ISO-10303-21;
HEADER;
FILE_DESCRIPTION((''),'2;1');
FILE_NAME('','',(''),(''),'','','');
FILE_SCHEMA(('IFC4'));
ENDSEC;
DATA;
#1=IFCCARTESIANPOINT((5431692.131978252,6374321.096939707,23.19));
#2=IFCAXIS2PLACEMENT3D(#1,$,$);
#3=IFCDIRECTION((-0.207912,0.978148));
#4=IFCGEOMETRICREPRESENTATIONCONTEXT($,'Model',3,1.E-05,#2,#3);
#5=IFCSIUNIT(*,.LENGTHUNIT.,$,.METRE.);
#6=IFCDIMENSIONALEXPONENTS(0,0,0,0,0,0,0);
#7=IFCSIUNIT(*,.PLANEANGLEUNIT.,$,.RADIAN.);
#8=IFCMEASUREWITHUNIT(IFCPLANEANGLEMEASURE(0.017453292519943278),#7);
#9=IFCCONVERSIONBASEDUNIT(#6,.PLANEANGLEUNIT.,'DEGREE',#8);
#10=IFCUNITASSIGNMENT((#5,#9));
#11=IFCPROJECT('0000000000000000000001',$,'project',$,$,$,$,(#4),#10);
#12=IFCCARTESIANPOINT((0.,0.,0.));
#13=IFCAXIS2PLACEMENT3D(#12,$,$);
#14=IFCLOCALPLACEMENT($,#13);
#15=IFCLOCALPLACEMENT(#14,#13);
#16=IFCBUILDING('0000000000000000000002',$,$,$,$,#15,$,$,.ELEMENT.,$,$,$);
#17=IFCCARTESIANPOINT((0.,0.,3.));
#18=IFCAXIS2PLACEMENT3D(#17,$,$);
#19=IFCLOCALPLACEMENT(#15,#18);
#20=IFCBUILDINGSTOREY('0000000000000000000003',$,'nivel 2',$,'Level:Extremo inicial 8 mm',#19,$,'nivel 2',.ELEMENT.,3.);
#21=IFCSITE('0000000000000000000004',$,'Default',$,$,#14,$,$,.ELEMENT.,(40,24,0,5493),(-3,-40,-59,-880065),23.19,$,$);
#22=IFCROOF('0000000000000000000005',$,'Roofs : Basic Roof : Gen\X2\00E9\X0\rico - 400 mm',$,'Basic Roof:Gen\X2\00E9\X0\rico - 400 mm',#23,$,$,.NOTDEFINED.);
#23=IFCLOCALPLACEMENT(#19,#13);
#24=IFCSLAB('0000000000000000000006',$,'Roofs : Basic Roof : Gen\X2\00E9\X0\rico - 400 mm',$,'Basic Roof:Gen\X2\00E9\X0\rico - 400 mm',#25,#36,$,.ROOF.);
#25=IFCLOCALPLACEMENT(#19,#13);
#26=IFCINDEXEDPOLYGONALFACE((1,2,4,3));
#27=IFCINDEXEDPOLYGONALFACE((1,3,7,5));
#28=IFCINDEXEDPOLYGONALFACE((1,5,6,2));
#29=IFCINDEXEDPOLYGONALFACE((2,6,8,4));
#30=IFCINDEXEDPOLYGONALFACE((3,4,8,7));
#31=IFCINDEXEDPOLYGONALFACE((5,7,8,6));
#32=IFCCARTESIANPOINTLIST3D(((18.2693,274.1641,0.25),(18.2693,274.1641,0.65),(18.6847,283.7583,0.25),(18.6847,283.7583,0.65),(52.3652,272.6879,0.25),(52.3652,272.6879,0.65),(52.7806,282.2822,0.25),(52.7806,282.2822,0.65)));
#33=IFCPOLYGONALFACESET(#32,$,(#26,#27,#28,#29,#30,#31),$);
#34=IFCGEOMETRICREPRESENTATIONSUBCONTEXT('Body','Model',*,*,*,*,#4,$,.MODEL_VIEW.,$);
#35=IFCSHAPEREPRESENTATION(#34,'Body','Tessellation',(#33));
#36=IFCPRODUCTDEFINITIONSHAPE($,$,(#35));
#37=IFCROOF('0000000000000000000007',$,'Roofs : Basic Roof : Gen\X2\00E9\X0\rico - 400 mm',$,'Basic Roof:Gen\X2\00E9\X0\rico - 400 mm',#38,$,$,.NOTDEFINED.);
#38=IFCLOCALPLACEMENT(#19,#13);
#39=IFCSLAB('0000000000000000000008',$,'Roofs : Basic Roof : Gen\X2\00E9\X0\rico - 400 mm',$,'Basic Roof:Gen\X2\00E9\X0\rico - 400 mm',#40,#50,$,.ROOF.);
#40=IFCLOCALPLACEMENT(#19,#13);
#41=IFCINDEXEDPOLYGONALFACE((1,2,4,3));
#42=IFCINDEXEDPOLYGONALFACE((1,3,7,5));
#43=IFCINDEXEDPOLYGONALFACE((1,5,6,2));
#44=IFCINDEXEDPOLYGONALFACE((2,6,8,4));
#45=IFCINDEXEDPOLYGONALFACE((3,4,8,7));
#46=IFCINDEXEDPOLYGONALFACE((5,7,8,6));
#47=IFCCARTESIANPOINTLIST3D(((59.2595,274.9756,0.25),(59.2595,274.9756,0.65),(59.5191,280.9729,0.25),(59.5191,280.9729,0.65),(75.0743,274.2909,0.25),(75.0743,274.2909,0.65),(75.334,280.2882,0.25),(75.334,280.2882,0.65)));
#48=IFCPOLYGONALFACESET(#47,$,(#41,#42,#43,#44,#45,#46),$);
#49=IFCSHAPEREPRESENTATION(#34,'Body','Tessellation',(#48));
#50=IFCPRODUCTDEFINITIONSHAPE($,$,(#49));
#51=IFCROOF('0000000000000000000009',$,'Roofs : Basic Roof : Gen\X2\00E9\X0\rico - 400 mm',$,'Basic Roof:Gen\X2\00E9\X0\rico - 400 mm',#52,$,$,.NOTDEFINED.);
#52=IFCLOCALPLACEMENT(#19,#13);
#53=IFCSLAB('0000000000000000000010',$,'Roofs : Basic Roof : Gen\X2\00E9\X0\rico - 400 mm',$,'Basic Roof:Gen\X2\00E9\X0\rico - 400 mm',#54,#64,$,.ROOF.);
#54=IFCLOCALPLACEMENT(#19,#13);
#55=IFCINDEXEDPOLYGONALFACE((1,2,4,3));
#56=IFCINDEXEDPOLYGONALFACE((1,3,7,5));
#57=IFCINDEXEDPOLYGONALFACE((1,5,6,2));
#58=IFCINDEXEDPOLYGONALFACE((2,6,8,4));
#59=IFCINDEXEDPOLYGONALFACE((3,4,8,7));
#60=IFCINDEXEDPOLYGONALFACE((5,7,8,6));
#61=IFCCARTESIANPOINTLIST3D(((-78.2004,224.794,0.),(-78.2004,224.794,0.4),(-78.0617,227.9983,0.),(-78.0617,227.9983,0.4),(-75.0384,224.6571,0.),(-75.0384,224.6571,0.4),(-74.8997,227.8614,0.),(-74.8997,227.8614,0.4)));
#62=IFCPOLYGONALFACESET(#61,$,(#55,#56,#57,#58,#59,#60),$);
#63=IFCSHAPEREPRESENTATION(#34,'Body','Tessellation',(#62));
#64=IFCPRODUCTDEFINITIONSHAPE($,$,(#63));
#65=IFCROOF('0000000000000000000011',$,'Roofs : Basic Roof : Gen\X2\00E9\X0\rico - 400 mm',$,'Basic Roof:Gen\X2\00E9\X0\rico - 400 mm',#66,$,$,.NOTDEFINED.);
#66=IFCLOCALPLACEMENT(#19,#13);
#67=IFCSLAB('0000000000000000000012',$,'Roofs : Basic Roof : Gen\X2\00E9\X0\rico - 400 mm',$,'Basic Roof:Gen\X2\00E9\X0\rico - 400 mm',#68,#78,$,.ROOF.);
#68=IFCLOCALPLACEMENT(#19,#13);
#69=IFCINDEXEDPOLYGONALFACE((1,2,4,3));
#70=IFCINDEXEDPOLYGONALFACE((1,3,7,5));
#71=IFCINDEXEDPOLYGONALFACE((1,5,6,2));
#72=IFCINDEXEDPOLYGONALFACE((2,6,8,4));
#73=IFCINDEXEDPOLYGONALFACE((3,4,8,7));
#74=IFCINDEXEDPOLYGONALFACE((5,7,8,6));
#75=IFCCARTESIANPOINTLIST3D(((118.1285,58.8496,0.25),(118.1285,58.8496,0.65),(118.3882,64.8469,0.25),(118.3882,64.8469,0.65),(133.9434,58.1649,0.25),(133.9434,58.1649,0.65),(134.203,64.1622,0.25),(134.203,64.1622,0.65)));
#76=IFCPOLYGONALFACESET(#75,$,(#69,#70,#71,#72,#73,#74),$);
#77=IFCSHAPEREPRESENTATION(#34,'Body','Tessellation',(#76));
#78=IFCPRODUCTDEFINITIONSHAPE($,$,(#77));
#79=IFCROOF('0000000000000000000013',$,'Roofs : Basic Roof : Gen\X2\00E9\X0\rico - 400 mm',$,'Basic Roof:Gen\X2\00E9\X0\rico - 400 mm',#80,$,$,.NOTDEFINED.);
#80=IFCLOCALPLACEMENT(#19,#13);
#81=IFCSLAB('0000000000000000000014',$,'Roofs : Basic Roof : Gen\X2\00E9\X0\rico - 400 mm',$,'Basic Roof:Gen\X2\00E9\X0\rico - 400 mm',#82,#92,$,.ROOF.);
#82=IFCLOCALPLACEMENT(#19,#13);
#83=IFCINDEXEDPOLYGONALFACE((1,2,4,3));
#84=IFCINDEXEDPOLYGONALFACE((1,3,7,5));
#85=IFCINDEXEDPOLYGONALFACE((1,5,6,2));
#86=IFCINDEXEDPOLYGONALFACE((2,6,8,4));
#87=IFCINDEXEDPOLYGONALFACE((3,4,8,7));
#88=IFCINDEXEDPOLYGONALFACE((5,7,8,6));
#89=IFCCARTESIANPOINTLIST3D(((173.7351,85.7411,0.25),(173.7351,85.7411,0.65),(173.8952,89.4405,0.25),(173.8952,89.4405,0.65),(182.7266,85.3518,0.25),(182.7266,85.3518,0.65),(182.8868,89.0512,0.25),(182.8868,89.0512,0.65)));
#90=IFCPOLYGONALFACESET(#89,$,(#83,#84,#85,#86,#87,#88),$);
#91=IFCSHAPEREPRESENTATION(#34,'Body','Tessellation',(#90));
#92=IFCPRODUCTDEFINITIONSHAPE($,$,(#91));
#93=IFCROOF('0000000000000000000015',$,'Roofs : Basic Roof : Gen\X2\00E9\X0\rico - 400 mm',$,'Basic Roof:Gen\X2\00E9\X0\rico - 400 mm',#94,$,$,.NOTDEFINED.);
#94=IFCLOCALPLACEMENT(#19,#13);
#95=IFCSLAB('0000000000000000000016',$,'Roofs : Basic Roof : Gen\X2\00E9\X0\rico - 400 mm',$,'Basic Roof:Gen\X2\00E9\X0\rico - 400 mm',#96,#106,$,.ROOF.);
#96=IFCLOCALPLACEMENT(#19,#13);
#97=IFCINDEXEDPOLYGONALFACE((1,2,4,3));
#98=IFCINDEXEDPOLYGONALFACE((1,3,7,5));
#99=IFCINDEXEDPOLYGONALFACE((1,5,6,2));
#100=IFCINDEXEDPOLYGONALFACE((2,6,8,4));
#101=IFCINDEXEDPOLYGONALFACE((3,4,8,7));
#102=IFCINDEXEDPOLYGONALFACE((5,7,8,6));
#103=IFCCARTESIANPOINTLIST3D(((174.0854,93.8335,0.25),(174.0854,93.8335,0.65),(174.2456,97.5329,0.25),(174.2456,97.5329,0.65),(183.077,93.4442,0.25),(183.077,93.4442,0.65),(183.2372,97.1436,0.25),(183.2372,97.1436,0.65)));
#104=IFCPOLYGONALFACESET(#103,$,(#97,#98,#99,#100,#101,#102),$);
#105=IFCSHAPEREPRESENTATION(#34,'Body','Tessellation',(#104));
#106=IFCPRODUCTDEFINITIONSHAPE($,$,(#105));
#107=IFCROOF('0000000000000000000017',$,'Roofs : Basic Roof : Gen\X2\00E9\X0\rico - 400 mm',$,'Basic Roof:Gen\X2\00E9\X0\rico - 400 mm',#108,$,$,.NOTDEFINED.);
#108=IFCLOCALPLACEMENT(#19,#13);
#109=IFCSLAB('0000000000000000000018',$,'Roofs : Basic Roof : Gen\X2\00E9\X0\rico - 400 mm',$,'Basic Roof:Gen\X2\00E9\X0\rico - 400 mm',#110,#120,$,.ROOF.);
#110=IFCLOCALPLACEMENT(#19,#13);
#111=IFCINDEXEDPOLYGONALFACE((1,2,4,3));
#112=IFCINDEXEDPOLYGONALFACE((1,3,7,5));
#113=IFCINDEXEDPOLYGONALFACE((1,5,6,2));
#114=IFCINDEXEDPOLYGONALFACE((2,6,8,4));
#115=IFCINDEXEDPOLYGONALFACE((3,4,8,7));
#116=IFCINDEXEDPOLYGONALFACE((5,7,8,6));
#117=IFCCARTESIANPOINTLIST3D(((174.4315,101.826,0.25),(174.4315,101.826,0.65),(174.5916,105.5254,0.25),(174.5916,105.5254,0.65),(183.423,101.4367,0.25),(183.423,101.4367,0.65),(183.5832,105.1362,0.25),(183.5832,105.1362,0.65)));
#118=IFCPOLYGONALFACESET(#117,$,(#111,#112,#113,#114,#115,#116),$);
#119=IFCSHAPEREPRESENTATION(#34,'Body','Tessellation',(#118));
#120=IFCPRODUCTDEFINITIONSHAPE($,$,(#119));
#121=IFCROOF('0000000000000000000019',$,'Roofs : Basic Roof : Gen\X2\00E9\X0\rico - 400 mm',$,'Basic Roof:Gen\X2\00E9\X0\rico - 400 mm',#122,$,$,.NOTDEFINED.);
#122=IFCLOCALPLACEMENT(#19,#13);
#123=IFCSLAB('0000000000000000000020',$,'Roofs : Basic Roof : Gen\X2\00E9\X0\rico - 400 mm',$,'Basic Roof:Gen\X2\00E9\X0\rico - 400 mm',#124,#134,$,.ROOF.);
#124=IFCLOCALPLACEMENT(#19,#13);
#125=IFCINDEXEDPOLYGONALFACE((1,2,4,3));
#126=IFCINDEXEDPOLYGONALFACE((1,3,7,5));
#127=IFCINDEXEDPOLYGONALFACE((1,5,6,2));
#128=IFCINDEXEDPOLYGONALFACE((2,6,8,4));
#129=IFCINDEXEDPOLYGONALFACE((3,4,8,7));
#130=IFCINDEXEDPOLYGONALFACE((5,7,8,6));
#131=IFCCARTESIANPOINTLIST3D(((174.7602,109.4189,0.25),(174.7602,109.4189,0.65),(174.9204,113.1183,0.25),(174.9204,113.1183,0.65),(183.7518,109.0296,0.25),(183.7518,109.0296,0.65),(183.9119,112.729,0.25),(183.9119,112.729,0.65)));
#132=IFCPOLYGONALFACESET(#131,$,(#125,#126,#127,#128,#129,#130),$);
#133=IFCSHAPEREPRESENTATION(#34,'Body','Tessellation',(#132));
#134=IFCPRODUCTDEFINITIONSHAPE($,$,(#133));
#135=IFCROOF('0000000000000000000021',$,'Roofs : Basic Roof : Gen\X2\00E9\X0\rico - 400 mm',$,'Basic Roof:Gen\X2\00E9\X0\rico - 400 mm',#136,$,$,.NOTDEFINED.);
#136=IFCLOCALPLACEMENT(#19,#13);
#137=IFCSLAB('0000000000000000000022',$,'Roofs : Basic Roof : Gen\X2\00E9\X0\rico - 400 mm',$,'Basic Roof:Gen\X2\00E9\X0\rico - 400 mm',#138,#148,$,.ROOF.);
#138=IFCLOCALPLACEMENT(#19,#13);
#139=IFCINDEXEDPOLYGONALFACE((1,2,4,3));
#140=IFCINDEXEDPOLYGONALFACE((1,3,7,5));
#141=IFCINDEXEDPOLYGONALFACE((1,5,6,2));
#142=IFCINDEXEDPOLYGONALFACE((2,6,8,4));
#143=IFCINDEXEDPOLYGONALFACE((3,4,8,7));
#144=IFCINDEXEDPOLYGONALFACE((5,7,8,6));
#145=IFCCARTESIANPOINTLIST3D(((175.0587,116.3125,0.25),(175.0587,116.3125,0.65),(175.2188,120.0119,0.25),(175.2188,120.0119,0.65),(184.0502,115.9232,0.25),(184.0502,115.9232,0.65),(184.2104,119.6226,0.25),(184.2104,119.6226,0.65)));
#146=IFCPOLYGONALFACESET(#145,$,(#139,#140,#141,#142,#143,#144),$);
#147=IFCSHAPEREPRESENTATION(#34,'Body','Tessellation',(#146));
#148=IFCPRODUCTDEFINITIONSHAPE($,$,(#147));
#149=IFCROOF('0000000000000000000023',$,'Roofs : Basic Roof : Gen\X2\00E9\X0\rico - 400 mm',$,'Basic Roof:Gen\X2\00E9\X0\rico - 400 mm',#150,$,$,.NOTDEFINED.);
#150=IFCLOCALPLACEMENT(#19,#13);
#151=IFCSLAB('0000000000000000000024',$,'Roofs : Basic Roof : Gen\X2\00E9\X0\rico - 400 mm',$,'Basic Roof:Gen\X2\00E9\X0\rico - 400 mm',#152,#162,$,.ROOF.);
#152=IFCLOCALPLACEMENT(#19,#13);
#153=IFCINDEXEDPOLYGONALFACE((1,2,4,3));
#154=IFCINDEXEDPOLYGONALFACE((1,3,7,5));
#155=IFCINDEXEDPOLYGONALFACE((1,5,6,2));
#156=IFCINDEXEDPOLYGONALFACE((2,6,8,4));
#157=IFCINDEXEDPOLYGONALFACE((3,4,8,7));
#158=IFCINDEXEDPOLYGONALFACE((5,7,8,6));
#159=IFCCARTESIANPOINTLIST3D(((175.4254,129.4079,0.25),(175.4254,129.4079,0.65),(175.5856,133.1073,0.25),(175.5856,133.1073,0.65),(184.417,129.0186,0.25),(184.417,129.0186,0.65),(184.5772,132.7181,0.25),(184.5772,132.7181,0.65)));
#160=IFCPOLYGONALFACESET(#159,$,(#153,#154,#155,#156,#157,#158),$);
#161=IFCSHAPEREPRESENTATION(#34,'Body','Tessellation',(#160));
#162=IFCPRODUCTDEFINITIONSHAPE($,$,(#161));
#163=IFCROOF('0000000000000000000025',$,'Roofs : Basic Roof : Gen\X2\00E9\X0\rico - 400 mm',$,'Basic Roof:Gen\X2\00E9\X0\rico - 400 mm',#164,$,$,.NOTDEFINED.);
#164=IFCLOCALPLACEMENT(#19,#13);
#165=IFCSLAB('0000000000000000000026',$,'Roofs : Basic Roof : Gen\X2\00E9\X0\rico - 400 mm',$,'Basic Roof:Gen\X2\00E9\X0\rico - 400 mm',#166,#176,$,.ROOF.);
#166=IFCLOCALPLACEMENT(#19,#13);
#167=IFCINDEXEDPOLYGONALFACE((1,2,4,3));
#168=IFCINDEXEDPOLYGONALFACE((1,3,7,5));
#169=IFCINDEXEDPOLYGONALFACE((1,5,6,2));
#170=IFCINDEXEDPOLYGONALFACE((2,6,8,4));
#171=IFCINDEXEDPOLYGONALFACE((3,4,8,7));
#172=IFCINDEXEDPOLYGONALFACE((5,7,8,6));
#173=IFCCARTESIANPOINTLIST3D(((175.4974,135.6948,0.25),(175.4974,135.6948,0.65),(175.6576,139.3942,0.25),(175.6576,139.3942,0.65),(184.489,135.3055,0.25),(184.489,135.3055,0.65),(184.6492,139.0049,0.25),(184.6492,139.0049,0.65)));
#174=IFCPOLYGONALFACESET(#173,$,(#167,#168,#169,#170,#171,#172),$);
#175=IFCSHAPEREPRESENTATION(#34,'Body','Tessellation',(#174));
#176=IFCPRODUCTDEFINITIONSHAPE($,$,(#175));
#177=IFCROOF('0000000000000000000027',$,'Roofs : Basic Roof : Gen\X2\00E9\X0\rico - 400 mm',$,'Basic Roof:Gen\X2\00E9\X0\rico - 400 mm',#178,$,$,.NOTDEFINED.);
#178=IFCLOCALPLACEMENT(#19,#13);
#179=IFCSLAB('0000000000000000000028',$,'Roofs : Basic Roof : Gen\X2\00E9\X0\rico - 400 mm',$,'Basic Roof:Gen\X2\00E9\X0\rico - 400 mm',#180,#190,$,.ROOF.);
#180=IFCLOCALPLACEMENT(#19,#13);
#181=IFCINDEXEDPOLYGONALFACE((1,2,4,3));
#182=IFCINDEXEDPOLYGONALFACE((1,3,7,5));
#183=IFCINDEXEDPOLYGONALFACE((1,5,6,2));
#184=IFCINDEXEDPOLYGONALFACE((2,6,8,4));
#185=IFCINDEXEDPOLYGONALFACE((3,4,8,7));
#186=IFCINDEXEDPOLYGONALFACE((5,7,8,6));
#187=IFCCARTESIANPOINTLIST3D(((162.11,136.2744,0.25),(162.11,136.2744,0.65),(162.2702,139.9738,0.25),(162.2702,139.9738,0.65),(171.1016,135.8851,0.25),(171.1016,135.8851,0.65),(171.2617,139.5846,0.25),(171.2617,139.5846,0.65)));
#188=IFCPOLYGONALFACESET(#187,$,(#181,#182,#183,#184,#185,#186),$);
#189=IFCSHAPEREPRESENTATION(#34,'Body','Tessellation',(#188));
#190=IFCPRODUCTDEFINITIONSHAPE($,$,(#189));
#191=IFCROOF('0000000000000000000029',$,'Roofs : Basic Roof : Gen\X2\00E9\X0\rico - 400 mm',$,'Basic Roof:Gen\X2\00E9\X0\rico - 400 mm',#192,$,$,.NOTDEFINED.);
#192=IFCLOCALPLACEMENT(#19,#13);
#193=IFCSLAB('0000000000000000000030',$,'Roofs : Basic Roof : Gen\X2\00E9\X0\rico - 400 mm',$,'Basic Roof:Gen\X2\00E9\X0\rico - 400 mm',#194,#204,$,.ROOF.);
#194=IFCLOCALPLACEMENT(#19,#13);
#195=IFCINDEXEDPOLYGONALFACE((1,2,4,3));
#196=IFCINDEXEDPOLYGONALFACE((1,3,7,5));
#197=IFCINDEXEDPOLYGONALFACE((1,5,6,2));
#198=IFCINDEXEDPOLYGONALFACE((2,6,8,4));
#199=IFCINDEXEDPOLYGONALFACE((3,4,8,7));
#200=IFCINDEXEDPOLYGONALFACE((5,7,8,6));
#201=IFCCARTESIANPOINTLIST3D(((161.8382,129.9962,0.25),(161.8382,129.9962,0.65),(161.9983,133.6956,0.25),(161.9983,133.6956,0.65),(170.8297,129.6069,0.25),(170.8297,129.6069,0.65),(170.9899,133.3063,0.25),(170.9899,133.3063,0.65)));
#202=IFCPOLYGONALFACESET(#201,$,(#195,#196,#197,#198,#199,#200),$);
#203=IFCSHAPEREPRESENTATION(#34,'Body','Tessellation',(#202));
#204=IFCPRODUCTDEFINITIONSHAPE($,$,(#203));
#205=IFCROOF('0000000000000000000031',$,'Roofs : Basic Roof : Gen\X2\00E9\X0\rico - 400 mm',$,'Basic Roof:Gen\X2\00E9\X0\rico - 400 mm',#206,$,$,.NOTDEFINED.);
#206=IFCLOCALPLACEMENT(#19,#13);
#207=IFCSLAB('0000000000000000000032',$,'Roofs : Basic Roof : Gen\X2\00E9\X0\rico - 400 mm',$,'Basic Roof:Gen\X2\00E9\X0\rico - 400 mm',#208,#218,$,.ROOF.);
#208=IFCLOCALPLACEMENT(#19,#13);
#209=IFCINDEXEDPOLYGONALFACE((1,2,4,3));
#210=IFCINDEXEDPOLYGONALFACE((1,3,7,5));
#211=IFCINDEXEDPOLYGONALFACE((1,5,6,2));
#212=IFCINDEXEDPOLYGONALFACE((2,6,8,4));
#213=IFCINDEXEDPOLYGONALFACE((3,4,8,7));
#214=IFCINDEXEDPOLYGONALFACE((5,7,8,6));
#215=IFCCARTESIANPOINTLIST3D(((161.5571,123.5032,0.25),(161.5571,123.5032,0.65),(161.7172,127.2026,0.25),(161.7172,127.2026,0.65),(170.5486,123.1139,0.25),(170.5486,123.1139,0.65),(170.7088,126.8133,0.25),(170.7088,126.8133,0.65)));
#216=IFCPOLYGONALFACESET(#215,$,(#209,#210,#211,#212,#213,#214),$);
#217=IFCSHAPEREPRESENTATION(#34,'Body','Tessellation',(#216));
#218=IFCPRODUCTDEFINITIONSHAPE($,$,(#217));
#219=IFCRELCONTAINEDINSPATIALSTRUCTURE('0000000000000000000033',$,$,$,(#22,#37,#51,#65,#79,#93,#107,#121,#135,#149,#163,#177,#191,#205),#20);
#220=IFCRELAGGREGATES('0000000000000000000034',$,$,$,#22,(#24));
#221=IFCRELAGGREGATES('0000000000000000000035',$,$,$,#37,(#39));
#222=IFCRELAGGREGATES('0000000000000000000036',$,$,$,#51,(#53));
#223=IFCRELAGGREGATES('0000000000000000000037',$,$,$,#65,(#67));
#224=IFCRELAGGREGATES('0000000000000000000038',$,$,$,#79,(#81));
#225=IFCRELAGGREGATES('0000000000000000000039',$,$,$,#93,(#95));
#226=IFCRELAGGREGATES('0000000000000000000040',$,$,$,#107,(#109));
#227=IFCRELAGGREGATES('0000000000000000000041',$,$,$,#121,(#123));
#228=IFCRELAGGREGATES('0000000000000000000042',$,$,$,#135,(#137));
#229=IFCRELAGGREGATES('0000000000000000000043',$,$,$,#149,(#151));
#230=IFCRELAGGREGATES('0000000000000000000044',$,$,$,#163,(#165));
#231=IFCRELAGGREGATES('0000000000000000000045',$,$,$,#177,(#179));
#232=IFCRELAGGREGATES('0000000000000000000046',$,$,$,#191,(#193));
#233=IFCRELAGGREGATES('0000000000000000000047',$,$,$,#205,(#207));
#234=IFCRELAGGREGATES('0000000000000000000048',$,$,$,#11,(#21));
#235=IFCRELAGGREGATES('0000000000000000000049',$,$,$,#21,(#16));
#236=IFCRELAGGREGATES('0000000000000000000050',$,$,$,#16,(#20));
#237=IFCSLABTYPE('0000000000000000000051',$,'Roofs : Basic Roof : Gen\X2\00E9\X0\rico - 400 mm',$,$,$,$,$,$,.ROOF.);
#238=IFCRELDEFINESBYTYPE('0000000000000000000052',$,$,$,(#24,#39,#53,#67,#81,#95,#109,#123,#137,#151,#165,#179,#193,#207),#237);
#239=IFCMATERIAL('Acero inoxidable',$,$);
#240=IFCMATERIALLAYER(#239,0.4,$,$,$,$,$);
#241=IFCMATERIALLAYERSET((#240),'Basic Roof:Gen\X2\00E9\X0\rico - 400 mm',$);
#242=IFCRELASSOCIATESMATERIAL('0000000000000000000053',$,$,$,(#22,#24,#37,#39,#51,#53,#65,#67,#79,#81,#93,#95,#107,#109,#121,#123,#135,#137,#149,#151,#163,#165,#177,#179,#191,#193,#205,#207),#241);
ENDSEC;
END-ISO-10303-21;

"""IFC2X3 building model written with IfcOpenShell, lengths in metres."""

from ifc_helpers import new_model, entity, si_unit, converted_unit, direction, frame, frame_2d, origin, place, context, subcontext, project, spatial, rectangle, extrude, material, layer, layer_set, type_object, element, aggregate, save


model = new_model("IFC2X3")

# Units and contexts
model_context = context("Model", 3, precision=1e-05, world=frame((5431692.131978252, 6374321.096939707, 23.19)), true_north=direction((-0.207912, 0.978148)))
body_context = subcontext(model_context, "Body", "Model", "MODEL_VIEW")
ifc_project = project(units=[si_unit("LENGTHUNIT", "METRE"), converted_unit("PLANEANGLEUNIT", "DEGREE", entity("IfcPlaneAngleMeasure", 0.017453292519943278), si_unit("PLANEANGLEUNIT", "RADIAN"), dimensions=[0, 0, 0, 0, 0, 0, 0])], contexts=[model_context])

# Site, building, storey
site_placement = place(None, origin())
site = spatial("IfcSite", under=ifc_project, at=site_placement, Name="Default", CompositionType="ELEMENT", RefLatitude=(40, 24, 0, 5493), RefLongitude=(-3, -40, -59, -880065), RefElevation=23.19)
building_placement = place(site_placement, origin())
building = spatial("IfcBuilding", under=site, at=building_placement, CompositionType="ELEMENT")
storey_placement = place(building_placement, frame((0.0, 0.0, 3.0)))
storey = spatial("IfcBuildingStorey", under=building, at=storey_placement, Name="nivel 2", ObjectType="Level:Extremo inicial 8 mm", LongName="nivel 2", CompositionType="ELEMENT", Elevation=3.0)

# Roofs, slabs
ifc_material_1 = material(Name="Acero inoxidable")
ifc_layer_1 = layer(ifc_material_1, 0.4)
ifc_layer_set_1 = layer_set([ifc_layer_1], Name="Basic Roof:Genérico - 400 mm")
roof_1_placement = place(storey_placement, frame((18.2693, 272.6879, 0.25)))
roof_1 = element("IfcRoof", 1, at=roof_1_placement, inside=storey, material=ifc_layer_set_1, Name="Roofs : Basic Roof : Genérico - 400 mm", ObjectType="Basic Roof:Genérico - 400 mm", ShapeType="NOTDEFINED")
slab_type = type_object("IfcSlabType", Name="Roofs : Basic Roof : Genérico - 400 mm", PredefinedType="ROOF")
slab_1_placement = place(roof_1_placement, origin())
slab_1 = element("IfcSlab", 2, at=slab_1_placement, type_object=slab_type, material=ifc_layer_set_1, Name="Roofs : Basic Roof : Genérico - 400 mm", ObjectType="Basic Roof:Genérico - 400 mm", PredefinedType="ROOF", context=body_context, shape_type="SweptSolid", body=[
    extrude(rectangle(XDim=9.6032, YDim=34.1278, at=frame_2d((0.0, 0.0), x_axis=(0.043255, 0.999064))), frame((17.2556, 5.5352, 0.0)), (0.0, 0.0, 1.0), 0.4),
])
aggregate(roof_1, [slab_1])
roof_2_placement = place(storey_placement, frame((59.2595, 274.2909, 0.25)))
roof_2 = element("IfcRoof", 3, at=roof_2_placement, inside=storey, material=ifc_layer_set_1, Name="Roofs : Basic Roof : Genérico - 400 mm", ObjectType="Basic Roof:Genérico - 400 mm", ShapeType="NOTDEFINED")
slab_2_placement = place(roof_2_placement, origin())
slab_2 = element("IfcSlab", 4, at=slab_2_placement, type_object=slab_type, material=ifc_layer_set_1, Name="Roofs : Basic Roof : Genérico - 400 mm", ObjectType="Basic Roof:Genérico - 400 mm", PredefinedType="ROOF", context=body_context, shape_type="SweptSolid", body=[
    extrude(rectangle(XDim=6.0029, YDim=15.8297, at=frame_2d((0.0, 0.0), x_axis=(0.043255, 0.999064))), frame((8.0373, 3.341, 0.0)), (0.0, 0.0, 1.0), 0.4),
])
aggregate(roof_2, [slab_2])

# Roofs, slabs
roof_3_placement = place(storey_placement, frame((-78.2004, 224.6571, 0.0)))
roof_3 = element("IfcRoof", 5, at=roof_3_placement, inside=storey, material=ifc_layer_set_1, Name="Roofs : Basic Roof : Genérico - 400 mm", ObjectType="Basic Roof:Genérico - 400 mm", ShapeType="NOTDEFINED")
slab_3_placement = place(roof_3_placement, origin())
slab_3 = element("IfcSlab", 6, at=slab_3_placement, type_object=slab_type, material=ifc_layer_set_1, Name="Roofs : Basic Roof : Genérico - 400 mm", ObjectType="Basic Roof:Genérico - 400 mm", PredefinedType="ROOF", context=body_context, shape_type="SweptSolid", body=[
    extrude(rectangle(XDim=3.165, YDim=3.2073, at=frame_2d((0.0, 0.0), x_axis=(0.999064, -0.043255))), frame((1.6504, 1.6706, 0.0)), (0.0, 0.0, 1.0), 0.4),
])
aggregate(roof_3, [slab_3])
roof_4_placement = place(storey_placement, frame((118.1285, 58.1649, 0.25)))
roof_4 = element("IfcRoof", 7, at=roof_4_placement, inside=storey, material=ifc_layer_set_1, Name="Roofs : Basic Roof : Genérico - 400 mm", ObjectType="Basic Roof:Genérico - 400 mm", ShapeType="NOTDEFINED")
slab_4_placement = place(roof_4_placement, origin())
slab_4 = element("IfcSlab", 8, at=slab_4_placement, type_object=slab_type, material=ifc_layer_set_1, Name="Roofs : Basic Roof : Genérico - 400 mm", ObjectType="Basic Roof:Genérico - 400 mm", PredefinedType="ROOF", context=body_context, shape_type="SweptSolid", body=[
    extrude(rectangle(XDim=6.0029, YDim=15.8297, at=frame_2d((0.0, 0.0), x_axis=(0.043255, 0.999064))), frame((8.0373, 3.341, 0.0)), (0.0, 0.0, 1.0), 0.4),
])
aggregate(roof_4, [slab_4])
roof_5_placement = place(storey_placement, frame((173.7351, 85.3518, 0.25)))
roof_5 = element("IfcRoof", 9, at=roof_5_placement, inside=storey, material=ifc_layer_set_1, Name="Roofs : Basic Roof : Genérico - 400 mm", ObjectType="Basic Roof:Genérico - 400 mm", ShapeType="NOTDEFINED")
slab_5_placement = place(roof_5_placement, origin())
slab_5 = element("IfcSlab", 10, at=slab_5_placement, type_object=slab_type, material=ifc_layer_set_1, Name="Roofs : Basic Roof : Genérico - 400 mm", ObjectType="Basic Roof:Genérico - 400 mm", PredefinedType="ROOF", context=body_context, shape_type="SweptSolid", body=[
    extrude(rectangle(XDim=3.7029, YDim=9.0, at=frame_2d((0.0, 0.0), x_axis=(0.043255, 0.999064))), frame((4.5759, 2.0444, 0.0)), (0.0, 0.0, 1.0), 0.4),
])
aggregate(roof_5, [slab_5])
roof_6_placement = place(storey_placement, frame((174.0854, 93.4442, 0.25)))
roof_6 = element("IfcRoof", 11, at=roof_6_placement, inside=storey, material=ifc_layer_set_1, Name="Roofs : Basic Roof : Genérico - 400 mm", ObjectType="Basic Roof:Genérico - 400 mm", ShapeType="NOTDEFINED")
slab_6_placement = place(roof_6_placement, origin())
slab_6 = element("IfcSlab", 12, at=slab_6_placement, type_object=slab_type, material=ifc_layer_set_1, Name="Roofs : Basic Roof : Genérico - 400 mm", ObjectType="Basic Roof:Genérico - 400 mm", PredefinedType="ROOF", context=body_context, shape_type="SweptSolid", body=[
    extrude(rectangle(XDim=3.7029, YDim=9.0, at=frame_2d((0.0, 0.0), x_axis=(0.043255, 0.999064))), frame((4.5759, 2.0444, 0.0)), (0.0, 0.0, 1.0), 0.4),
])
aggregate(roof_6, [slab_6])
roof_7_placement = place(storey_placement, frame((174.4315, 101.4367, 0.25)))
roof_7 = element("IfcRoof", 13, at=roof_7_placement, inside=storey, material=ifc_layer_set_1, Name="Roofs : Basic Roof : Genérico - 400 mm", ObjectType="Basic Roof:Genérico - 400 mm", ShapeType="NOTDEFINED")
slab_7_placement = place(roof_7_placement, origin())
slab_7 = element("IfcSlab", 14, at=slab_7_placement, type_object=slab_type, material=ifc_layer_set_1, Name="Roofs : Basic Roof : Genérico - 400 mm", ObjectType="Basic Roof:Genérico - 400 mm", PredefinedType="ROOF", context=body_context, shape_type="SweptSolid", body=[
    extrude(rectangle(XDim=3.7029, YDim=9.0, at=frame_2d((0.0, 0.0), x_axis=(0.043255, 0.999064))), frame((4.5759, 2.0444, 0.0)), (0.0, 0.0, 1.0), 0.4),
])
aggregate(roof_7, [slab_7])
roof_8_placement = place(storey_placement, frame((174.7602, 109.0296, 0.25)))
roof_8 = element("IfcRoof", 15, at=roof_8_placement, inside=storey, material=ifc_layer_set_1, Name="Roofs : Basic Roof : Genérico - 400 mm", ObjectType="Basic Roof:Genérico - 400 mm", ShapeType="NOTDEFINED")
slab_8_placement = place(roof_8_placement, origin())
slab_8 = element("IfcSlab", 16, at=slab_8_placement, type_object=slab_type, material=ifc_layer_set_1, Name="Roofs : Basic Roof : Genérico - 400 mm", ObjectType="Basic Roof:Genérico - 400 mm", PredefinedType="ROOF", context=body_context, shape_type="SweptSolid", body=[
    extrude(rectangle(XDim=3.7029, YDim=9.0, at=frame_2d((0.0, 0.0), x_axis=(0.043255, 0.999064))), frame((4.5759, 2.0444, 0.0)), (0.0, 0.0, 1.0), 0.4),
])
aggregate(roof_8, [slab_8])
roof_9_placement = place(storey_placement, frame((175.0587, 115.9232, 0.25)))
roof_9 = element("IfcRoof", 17, at=roof_9_placement, inside=storey, material=ifc_layer_set_1, Name="Roofs : Basic Roof : Genérico - 400 mm", ObjectType="Basic Roof:Genérico - 400 mm", ShapeType="NOTDEFINED")
slab_9_placement = place(roof_9_placement, origin())
slab_9 = element("IfcSlab", 18, at=slab_9_placement, type_object=slab_type, material=ifc_layer_set_1, Name="Roofs : Basic Roof : Genérico - 400 mm", ObjectType="Basic Roof:Genérico - 400 mm", PredefinedType="ROOF", context=body_context, shape_type="SweptSolid", body=[
    extrude(rectangle(XDim=3.7029, YDim=9.0, at=frame_2d((0.0, 0.0), x_axis=(0.043255, 0.999064))), frame((4.5759, 2.0444, 0.0)), (0.0, 0.0, 1.0), 0.4),
])
aggregate(roof_9, [slab_9])
roof_10_placement = place(storey_placement, frame((175.4254, 129.0186, 0.25)))
roof_10 = element("IfcRoof", 19, at=roof_10_placement, inside=storey, material=ifc_layer_set_1, Name="Roofs : Basic Roof : Genérico - 400 mm", ObjectType="Basic Roof:Genérico - 400 mm", ShapeType="NOTDEFINED")
slab_10_placement = place(roof_10_placement, origin())
slab_10 = element("IfcSlab", 20, at=slab_10_placement, type_object=slab_type, material=ifc_layer_set_1, Name="Roofs : Basic Roof : Genérico - 400 mm", ObjectType="Basic Roof:Genérico - 400 mm", PredefinedType="ROOF", context=body_context, shape_type="SweptSolid", body=[
    extrude(rectangle(XDim=3.7029, YDim=9.0, at=frame_2d((0.0, 0.0), x_axis=(0.043255, 0.999064))), frame((4.5759, 2.0444, 0.0)), (0.0, 0.0, 1.0), 0.4),
])
aggregate(roof_10, [slab_10])
roof_11_placement = place(storey_placement, frame((175.4974, 135.3055, 0.25)))
roof_11 = element("IfcRoof", 21, at=roof_11_placement, inside=storey, material=ifc_layer_set_1, Name="Roofs : Basic Roof : Genérico - 400 mm", ObjectType="Basic Roof:Genérico - 400 mm", ShapeType="NOTDEFINED")
slab_11_placement = place(roof_11_placement, origin())
slab_11 = element("IfcSlab", 22, at=slab_11_placement, type_object=slab_type, material=ifc_layer_set_1, Name="Roofs : Basic Roof : Genérico - 400 mm", ObjectType="Basic Roof:Genérico - 400 mm", PredefinedType="ROOF", context=body_context, shape_type="SweptSolid", body=[
    extrude(rectangle(XDim=3.7029, YDim=9.0, at=frame_2d((0.0, 0.0), x_axis=(0.043255, 0.999064))), frame((4.5759, 2.0444, 0.0)), (0.0, 0.0, 1.0), 0.4),
])
aggregate(roof_11, [slab_11])
roof_12_placement = place(storey_placement, frame((162.11, 135.8851, 0.25)))
roof_12 = element("IfcRoof", 23, at=roof_12_placement, inside=storey, material=ifc_layer_set_1, Name="Roofs : Basic Roof : Genérico - 400 mm", ObjectType="Basic Roof:Genérico - 400 mm", ShapeType="NOTDEFINED")
slab_12_placement = place(roof_12_placement, origin())
slab_12 = element("IfcSlab", 24, at=slab_12_placement, type_object=slab_type, material=ifc_layer_set_1, Name="Roofs : Basic Roof : Genérico - 400 mm", ObjectType="Basic Roof:Genérico - 400 mm", PredefinedType="ROOF", context=body_context, shape_type="SweptSolid", body=[
    extrude(rectangle(XDim=3.7029, YDim=9.0, at=frame_2d((0.0, 0.0), x_axis=(0.043255, 0.999064))), frame((4.5759, 2.0444, 0.0)), (0.0, 0.0, 1.0), 0.4),
])
aggregate(roof_12, [slab_12])
roof_13_placement = place(storey_placement, frame((161.8382, 129.6069, 0.25)))
roof_13 = element("IfcRoof", 25, at=roof_13_placement, inside=storey, material=ifc_layer_set_1, Name="Roofs : Basic Roof : Genérico - 400 mm", ObjectType="Basic Roof:Genérico - 400 mm", ShapeType="NOTDEFINED")
slab_13_placement = place(roof_13_placement, origin())
slab_13 = element("IfcSlab", 26, at=slab_13_placement, type_object=slab_type, material=ifc_layer_set_1, Name="Roofs : Basic Roof : Genérico - 400 mm", ObjectType="Basic Roof:Genérico - 400 mm", PredefinedType="ROOF", context=body_context, shape_type="SweptSolid", body=[
    extrude(rectangle(XDim=3.7029, YDim=9.0, at=frame_2d((0.0, 0.0), x_axis=(0.043255, 0.999064))), frame((4.5759, 2.0444, 0.0)), (0.0, 0.0, 1.0), 0.4),
])
aggregate(roof_13, [slab_13])
roof_14_placement = place(storey_placement, frame((161.5571, 123.1139, 0.25)))
roof_14 = element("IfcRoof", 27, at=roof_14_placement, inside=storey, material=ifc_layer_set_1, Name="Roofs : Basic Roof : Genérico - 400 mm", ObjectType="Basic Roof:Genérico - 400 mm", ShapeType="NOTDEFINED")
slab_14_placement = place(roof_14_placement, origin())
slab_14 = element("IfcSlab", 28, at=slab_14_placement, type_object=slab_type, material=ifc_layer_set_1, Name="Roofs : Basic Roof : Genérico - 400 mm", ObjectType="Basic Roof:Genérico - 400 mm", PredefinedType="ROOF", context=body_context, shape_type="SweptSolid", body=[
    extrude(rectangle(XDim=3.7029, YDim=9.0, at=frame_2d((0.0, 0.0), x_axis=(0.043255, 0.999064))), frame((4.5759, 2.0444, 0.0)), (0.0, 0.0, 1.0), 0.4),
])
aggregate(roof_14, [slab_14])

save(model, "model.ifc")
